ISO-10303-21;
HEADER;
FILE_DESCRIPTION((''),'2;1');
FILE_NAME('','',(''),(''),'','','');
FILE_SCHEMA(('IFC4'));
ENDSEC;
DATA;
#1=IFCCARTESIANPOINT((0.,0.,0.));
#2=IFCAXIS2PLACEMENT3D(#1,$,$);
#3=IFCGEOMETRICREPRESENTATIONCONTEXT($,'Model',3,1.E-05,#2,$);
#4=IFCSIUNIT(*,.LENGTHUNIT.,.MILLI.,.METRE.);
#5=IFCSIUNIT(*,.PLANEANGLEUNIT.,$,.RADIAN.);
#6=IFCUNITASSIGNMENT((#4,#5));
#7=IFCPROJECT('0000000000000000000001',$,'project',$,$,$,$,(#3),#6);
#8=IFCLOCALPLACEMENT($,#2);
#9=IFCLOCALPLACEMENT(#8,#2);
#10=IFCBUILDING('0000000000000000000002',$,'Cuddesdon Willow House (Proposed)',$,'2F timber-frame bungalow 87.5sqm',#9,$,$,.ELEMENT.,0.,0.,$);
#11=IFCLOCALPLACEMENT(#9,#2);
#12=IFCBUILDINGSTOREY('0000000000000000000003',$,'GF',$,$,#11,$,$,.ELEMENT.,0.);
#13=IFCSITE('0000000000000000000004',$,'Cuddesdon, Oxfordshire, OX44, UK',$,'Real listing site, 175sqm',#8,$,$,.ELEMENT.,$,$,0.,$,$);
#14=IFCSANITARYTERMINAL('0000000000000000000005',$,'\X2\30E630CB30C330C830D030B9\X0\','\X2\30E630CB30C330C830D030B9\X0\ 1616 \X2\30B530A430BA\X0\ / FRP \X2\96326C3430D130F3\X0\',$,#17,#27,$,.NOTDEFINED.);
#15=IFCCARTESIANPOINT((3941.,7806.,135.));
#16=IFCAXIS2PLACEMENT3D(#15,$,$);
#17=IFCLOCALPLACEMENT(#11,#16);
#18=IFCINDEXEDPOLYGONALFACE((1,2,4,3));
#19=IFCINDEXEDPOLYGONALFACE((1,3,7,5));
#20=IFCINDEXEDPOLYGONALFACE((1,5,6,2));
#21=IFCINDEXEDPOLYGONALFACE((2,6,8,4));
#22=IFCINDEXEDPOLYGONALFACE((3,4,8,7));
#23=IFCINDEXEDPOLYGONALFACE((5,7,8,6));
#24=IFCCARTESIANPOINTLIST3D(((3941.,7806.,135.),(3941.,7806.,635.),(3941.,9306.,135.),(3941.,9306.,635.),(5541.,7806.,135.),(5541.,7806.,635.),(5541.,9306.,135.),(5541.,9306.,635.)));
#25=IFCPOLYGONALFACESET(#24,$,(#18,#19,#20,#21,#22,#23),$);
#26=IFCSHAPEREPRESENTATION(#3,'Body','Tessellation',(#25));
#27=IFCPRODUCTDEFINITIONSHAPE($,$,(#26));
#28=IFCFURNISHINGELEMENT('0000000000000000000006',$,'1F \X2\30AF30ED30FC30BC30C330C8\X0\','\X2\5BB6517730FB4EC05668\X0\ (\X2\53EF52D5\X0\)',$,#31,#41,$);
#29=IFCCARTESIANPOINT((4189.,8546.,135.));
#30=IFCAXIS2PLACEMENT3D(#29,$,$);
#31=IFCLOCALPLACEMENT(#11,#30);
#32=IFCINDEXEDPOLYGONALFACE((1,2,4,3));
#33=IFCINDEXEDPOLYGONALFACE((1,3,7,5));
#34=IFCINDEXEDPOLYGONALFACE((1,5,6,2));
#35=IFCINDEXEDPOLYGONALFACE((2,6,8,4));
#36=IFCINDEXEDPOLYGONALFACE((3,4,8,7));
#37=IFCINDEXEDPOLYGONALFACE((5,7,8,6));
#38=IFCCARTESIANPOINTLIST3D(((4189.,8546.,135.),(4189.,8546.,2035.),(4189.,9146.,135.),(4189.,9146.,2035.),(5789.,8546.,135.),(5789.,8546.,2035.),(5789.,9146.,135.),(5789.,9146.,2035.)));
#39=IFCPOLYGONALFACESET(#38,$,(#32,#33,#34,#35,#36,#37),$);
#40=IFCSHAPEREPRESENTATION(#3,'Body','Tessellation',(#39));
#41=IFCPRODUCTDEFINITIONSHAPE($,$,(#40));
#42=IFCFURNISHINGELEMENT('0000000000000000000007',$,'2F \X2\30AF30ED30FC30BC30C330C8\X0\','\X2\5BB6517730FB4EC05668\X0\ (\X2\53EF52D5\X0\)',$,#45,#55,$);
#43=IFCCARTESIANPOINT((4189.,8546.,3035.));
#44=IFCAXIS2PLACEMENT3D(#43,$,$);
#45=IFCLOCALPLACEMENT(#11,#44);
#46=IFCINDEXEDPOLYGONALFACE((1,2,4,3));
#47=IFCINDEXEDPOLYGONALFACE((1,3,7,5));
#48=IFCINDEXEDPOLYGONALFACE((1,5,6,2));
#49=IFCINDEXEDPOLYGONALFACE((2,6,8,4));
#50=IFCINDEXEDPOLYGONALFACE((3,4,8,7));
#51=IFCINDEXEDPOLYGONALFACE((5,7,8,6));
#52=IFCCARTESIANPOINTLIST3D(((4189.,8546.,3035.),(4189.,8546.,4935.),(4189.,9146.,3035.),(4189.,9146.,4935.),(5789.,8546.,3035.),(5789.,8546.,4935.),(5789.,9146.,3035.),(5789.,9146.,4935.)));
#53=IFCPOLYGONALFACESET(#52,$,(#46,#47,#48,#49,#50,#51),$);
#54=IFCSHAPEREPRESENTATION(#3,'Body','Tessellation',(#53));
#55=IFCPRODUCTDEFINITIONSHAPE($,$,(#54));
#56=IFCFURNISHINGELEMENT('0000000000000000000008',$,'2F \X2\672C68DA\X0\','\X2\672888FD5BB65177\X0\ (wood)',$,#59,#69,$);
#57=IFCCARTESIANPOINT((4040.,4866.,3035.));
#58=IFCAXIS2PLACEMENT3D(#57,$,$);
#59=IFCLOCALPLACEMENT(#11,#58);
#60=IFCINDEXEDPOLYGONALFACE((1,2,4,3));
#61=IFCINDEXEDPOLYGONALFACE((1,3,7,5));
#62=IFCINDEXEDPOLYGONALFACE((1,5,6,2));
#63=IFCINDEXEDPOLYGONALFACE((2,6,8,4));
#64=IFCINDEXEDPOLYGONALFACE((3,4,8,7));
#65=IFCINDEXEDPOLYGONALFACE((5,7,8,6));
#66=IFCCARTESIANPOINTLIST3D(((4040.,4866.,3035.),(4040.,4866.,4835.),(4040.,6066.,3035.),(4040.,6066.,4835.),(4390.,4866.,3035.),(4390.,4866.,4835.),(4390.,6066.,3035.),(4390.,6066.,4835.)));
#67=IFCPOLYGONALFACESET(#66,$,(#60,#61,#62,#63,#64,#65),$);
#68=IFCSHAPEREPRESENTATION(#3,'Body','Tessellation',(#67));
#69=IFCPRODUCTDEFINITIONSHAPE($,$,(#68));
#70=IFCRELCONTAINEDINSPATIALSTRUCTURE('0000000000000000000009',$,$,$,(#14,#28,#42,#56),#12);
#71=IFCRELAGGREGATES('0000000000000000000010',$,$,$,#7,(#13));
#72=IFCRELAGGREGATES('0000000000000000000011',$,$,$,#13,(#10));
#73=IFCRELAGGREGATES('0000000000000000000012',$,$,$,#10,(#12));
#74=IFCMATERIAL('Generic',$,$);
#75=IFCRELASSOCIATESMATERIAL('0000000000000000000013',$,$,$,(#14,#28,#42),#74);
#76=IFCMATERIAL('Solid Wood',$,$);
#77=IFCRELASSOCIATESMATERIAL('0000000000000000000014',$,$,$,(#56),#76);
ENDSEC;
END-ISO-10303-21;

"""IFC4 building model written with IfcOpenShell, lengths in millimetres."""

from ifc_helpers import new_model, si_unit, frame, frame_2d, origin, place, context, project, spatial, rectangle, extrude, material, element, save


model = new_model("IFC4")

# Units and contexts
model_context = context("Model", 3, precision=1e-05, world=origin())
ifc_project = project(units=[si_unit("LENGTHUNIT", "METRE", prefix="MILLI"), si_unit("PLANEANGLEUNIT", "RADIAN")], contexts=[model_context])

# Site, building, storey
site_placement = place(None, origin())
site = spatial("IfcSite", under=ifc_project, at=site_placement, Name="Cuddesdon, Oxfordshire, OX44, UK", ObjectType="Real listing site, 175sqm", CompositionType="ELEMENT", RefElevation=0.0)
building_placement = place(site_placement, origin())
building = spatial("IfcBuilding", under=site, at=building_placement, Name="Cuddesdon Willow House (Proposed)", ObjectType="2F timber-frame bungalow 87.5sqm", CompositionType="ELEMENT", ElevationOfRefHeight=0.0, ElevationOfTerrain=0.0)
storey_placement = place(building_placement, origin())
storey = spatial("IfcBuildingStorey", under=building, at=storey_placement, Name="GF", CompositionType="ELEMENT", Elevation=0.0)

# Shared definitions
ifc_material_1 = material(Name="Solid Wood")

# Shared definitions
ifc_material_2 = material(Name="Generic")

# Sanitary terminal
sanitary_terminal_placement = place(storey_placement, frame((3941.0, 7806.0, 135.0)))
element("IfcSanitaryTerminal", 1, at=sanitary_terminal_placement, inside=storey, material=ifc_material_2, Name="ユニットバス", Description="ユニットバス 1616 サイズ / FRP 防水パン", PredefinedType="NOTDEFINED", context=model_context, shape_type="SweptSolid", body=[
    extrude(rectangle(XDim=1600.0, YDim=1500.0, at=frame_2d((800.0, 750.0))), frame((3941.0, 7806.0, 135.0)), (0.0, 0.0, 1.0), 500.0),
])

# Furnishing elements
furnishing_1_placement = place(storey_placement, frame((4189.0, 8546.0, 135.0)))
element("IfcFurnishingElement", 2, at=furnishing_1_placement, inside=storey, material=ifc_material_2, Name="1F クローゼット", Description="家具・什器 (可動)", context=model_context, shape_type="SweptSolid", body=[
    extrude(rectangle(XDim=1600.0, YDim=600.0, at=frame_2d((800.0, 300.0))), frame((4189.0, 8546.0, 135.0)), (0.0, 0.0, 1.0), 1900.0),
])
furnishing_2_placement = place(storey_placement, frame((4189.0, 8546.0, 3035.0)))
element("IfcFurnishingElement", 3, at=furnishing_2_placement, inside=storey, material=ifc_material_2, Name="2F クローゼット", Description="家具・什器 (可動)", context=model_context, shape_type="SweptSolid", body=[
    extrude(rectangle(XDim=1600.0, YDim=600.0, at=frame_2d((800.0, 300.0))), frame((4189.0, 8546.0, 3035.0)), (0.0, 0.0, 1.0), 1900.0),
])
furnishing_3_placement = place(storey_placement, frame((4040.0, 4866.0, 3035.0)))
element("IfcFurnishingElement", 4, at=furnishing_3_placement, inside=storey, material=ifc_material_1, Name="2F 本棚", Description="木製家具 (wood)", context=model_context, shape_type="SweptSolid", body=[
    extrude(rectangle(XDim=350.0, YDim=1200.0, at=frame_2d((175.0, 600.0))), frame((4040.0, 4866.0, 3035.0)), (0.0, 0.0, 1.0), 1800.0),
])

save(model, "model.ifc")
